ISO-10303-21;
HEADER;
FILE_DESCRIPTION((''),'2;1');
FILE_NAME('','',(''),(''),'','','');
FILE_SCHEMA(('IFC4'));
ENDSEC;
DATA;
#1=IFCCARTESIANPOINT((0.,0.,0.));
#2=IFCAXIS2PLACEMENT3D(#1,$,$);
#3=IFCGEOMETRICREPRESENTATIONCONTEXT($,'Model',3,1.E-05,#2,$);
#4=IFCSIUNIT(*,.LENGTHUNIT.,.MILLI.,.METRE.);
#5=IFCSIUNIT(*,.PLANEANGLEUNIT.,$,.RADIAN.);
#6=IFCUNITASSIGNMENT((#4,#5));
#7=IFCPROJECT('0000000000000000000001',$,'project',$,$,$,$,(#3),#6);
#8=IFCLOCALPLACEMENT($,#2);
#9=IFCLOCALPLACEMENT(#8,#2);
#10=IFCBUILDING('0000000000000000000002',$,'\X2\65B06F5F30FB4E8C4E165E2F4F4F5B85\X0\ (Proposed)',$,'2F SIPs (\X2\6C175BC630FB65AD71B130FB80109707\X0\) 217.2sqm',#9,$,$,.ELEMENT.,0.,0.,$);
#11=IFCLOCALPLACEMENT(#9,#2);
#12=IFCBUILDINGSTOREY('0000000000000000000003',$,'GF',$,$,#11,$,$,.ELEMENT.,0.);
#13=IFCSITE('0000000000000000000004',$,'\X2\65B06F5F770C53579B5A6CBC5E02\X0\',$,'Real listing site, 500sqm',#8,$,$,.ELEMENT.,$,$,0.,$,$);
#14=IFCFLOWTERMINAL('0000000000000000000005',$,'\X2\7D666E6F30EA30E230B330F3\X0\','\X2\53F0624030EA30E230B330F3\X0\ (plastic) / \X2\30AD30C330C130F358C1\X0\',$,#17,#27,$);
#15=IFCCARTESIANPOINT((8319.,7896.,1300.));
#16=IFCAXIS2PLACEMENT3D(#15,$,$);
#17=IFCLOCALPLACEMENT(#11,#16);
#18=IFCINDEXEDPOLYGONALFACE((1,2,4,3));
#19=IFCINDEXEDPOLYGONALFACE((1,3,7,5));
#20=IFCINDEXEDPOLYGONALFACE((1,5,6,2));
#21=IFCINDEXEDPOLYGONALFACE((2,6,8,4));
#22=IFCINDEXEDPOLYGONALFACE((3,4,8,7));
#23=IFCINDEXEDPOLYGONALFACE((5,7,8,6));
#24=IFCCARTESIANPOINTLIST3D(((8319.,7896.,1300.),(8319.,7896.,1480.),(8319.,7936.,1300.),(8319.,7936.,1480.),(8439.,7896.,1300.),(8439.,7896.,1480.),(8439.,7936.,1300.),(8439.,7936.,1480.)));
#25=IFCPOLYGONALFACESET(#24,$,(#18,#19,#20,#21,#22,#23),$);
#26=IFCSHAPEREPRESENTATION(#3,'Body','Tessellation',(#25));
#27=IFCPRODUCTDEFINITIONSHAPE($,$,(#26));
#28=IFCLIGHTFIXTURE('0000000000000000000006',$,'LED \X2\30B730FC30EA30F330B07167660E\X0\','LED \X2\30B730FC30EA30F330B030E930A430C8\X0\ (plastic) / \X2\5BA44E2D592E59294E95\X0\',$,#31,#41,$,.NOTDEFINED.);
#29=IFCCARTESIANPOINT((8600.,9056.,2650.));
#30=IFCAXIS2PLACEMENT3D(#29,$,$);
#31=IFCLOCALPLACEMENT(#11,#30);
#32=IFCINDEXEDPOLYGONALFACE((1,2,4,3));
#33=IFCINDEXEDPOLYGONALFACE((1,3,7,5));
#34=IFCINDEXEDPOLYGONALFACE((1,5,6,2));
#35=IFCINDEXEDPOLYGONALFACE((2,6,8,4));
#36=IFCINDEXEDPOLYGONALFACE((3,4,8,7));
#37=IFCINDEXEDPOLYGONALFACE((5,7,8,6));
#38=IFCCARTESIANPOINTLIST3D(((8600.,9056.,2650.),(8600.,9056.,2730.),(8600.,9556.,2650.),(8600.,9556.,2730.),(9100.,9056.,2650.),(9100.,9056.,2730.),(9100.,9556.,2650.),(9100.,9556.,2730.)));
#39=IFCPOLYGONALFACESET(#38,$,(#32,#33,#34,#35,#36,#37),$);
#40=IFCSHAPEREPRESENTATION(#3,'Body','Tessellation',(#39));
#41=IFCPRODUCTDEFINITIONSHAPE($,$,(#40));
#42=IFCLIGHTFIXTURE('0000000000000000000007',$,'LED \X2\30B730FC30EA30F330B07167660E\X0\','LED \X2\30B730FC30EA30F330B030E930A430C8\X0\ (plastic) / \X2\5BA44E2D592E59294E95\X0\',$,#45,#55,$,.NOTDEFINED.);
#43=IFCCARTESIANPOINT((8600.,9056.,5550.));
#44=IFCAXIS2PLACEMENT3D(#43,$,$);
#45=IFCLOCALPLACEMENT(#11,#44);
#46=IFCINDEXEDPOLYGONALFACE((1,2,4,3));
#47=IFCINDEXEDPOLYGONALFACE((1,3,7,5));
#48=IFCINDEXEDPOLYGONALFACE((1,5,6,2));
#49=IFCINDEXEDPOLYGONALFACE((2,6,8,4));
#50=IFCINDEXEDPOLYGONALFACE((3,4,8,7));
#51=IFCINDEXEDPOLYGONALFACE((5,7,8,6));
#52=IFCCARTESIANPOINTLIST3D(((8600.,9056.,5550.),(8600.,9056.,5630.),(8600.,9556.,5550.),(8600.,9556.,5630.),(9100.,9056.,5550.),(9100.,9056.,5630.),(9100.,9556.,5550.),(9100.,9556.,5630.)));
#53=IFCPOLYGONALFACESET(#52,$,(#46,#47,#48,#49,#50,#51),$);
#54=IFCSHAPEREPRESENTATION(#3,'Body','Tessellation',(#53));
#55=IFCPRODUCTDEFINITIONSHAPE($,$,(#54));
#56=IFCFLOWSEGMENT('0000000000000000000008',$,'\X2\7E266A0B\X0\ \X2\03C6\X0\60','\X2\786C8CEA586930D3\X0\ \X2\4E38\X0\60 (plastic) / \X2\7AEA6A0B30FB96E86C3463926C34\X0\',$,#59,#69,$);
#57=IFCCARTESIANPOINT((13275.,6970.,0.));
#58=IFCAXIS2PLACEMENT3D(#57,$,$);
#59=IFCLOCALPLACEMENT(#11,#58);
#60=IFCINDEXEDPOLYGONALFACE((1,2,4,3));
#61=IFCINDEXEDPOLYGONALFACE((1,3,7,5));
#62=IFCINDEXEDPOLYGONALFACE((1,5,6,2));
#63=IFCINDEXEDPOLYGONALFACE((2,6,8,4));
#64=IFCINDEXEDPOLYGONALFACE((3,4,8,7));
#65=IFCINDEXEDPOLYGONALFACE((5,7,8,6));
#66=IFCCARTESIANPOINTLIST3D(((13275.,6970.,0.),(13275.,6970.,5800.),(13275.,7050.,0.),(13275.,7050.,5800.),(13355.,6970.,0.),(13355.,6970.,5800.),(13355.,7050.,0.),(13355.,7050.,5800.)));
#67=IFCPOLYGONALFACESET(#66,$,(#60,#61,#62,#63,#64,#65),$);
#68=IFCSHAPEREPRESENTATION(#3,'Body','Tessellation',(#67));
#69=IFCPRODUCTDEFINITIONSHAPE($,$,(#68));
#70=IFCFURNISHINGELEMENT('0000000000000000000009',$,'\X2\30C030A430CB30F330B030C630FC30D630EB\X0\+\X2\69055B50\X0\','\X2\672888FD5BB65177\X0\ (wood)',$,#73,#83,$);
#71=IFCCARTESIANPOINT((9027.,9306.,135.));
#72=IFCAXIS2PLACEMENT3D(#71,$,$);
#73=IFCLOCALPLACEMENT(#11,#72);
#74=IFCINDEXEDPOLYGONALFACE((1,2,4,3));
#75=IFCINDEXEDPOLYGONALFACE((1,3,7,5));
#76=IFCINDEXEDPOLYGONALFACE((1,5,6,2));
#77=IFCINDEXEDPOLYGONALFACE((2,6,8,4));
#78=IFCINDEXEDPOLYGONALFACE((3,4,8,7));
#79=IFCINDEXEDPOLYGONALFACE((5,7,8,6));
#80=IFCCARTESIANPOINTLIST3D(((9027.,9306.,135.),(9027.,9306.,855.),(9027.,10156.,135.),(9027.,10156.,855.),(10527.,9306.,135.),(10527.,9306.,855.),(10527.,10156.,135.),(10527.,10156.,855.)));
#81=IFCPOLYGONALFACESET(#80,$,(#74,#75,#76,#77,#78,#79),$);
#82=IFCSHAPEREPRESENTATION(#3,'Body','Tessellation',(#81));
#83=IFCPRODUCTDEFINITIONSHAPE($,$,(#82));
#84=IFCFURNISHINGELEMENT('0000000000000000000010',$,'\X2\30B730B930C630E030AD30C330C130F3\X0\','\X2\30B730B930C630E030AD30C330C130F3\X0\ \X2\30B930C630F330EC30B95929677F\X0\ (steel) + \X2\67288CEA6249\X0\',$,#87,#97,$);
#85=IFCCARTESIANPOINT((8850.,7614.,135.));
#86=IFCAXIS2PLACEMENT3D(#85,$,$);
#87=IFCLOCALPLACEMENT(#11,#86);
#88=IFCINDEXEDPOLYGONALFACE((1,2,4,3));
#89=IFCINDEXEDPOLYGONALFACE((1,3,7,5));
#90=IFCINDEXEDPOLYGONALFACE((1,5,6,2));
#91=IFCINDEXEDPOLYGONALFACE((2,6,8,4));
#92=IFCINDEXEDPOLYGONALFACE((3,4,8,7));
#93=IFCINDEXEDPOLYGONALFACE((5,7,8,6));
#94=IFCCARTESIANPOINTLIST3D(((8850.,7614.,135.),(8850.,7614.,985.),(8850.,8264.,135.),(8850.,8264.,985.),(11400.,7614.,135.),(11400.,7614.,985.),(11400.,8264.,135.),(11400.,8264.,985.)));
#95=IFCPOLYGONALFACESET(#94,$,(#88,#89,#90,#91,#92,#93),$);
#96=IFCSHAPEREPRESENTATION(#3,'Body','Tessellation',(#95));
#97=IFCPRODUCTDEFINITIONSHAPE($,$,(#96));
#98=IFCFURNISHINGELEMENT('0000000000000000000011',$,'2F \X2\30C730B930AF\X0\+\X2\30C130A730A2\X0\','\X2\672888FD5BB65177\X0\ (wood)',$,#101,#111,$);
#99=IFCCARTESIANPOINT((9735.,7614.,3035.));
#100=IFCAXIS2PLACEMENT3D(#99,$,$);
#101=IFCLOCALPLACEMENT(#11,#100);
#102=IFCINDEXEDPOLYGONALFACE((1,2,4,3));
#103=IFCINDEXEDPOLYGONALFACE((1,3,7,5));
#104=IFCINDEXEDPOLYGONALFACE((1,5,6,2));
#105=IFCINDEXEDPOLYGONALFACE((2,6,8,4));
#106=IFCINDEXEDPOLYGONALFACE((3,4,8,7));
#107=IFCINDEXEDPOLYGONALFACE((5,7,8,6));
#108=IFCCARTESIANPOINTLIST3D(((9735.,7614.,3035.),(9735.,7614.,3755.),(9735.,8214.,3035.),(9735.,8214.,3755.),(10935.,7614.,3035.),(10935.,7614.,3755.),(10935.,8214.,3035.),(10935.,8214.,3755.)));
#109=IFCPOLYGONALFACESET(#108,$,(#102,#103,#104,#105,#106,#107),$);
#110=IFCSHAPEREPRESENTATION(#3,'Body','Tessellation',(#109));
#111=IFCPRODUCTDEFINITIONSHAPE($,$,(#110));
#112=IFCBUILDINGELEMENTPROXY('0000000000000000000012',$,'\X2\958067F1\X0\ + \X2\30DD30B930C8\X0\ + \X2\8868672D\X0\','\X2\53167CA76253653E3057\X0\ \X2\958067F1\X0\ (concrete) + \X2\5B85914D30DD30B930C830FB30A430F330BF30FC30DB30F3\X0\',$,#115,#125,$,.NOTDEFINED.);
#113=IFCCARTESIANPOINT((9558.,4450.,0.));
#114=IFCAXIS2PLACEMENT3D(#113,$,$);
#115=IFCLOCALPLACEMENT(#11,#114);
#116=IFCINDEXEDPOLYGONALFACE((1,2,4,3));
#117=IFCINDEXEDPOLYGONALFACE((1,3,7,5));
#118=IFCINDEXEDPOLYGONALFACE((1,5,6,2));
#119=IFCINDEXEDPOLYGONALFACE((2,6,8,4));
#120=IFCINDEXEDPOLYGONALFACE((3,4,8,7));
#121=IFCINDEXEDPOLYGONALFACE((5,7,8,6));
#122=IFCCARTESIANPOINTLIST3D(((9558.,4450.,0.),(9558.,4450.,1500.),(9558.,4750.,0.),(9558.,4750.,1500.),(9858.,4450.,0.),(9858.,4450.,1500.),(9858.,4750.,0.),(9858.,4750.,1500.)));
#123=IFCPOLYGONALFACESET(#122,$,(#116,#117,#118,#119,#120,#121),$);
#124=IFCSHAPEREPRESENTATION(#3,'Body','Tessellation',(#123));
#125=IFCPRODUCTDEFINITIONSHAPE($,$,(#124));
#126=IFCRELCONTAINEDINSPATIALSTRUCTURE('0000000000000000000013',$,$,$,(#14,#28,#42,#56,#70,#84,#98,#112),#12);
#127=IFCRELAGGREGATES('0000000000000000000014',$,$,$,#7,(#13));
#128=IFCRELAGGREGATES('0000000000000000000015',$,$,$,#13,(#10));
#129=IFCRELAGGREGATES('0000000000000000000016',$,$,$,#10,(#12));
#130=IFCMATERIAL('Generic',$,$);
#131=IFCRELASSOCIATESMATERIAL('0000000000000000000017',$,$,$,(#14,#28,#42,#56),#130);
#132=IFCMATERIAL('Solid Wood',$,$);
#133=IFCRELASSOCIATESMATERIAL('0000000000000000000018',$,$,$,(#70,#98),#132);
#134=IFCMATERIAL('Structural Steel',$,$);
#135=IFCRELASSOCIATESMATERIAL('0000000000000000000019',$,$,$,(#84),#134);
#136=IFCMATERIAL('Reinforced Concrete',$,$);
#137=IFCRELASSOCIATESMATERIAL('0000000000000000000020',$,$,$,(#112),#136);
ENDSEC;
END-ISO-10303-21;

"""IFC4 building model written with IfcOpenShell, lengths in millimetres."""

from ifc_helpers import new_model, si_unit, frame, frame_2d, origin, place, context, project, spatial, rectangle, extrude, material, element, save


model = new_model("IFC4")

# Units and contexts
model_context = context("Model", 3, precision=1e-05, world=origin())
ifc_project = project(units=[si_unit("LENGTHUNIT", "METRE", prefix="MILLI"), si_unit("PLANEANGLEUNIT", "RADIAN")], contexts=[model_context])

# Site, building, storey
site_placement = place(None, origin())
site = spatial("IfcSite", under=ifc_project, at=site_placement, Name="新潟県南魚沼市", ObjectType="Real listing site, 500sqm", CompositionType="ELEMENT", RefElevation=0.0)
building_placement = place(site_placement, origin())
building = spatial("IfcBuilding", under=site, at=building_placement, Name="新潟・二世帯住宅 (Proposed)", ObjectType="2F SIPs (気密・断熱・耐震) 217.2sqm", CompositionType="ELEMENT", ElevationOfRefHeight=0.0, ElevationOfTerrain=0.0)
storey_placement = place(building_placement, origin())
storey = spatial("IfcBuildingStorey", under=building, at=storey_placement, Name="GF", CompositionType="ELEMENT", Elevation=0.0)

# Shared definitions
ifc_material_1 = material(Name="Solid Wood")

# Shared definitions
ifc_material_2 = material(Name="Reinforced Concrete")

# Shared definitions
ifc_material_3 = material(Name="Structural Steel")

# Flow terminal
ifc_material_4 = material(Name="Generic")
flow_terminal_1_placement = place(storey_placement, frame((8319.0, 7896.0, 1300.0)))
element("IfcFlowTerminal", 1, at=flow_terminal_1_placement, inside=storey, material=ifc_material_4, Name="給湯リモコン", Description="台所リモコン (plastic) / キッチン壁", context=model_context, shape_type="SweptSolid", body=[
    extrude(rectangle(XDim=120.0, YDim=40.0, at=frame_2d((60.0, 20.0))), frame((8319.0, 7896.0, 1300.0)), (0.0, 0.0, 1.0), 180.0),
])

# Light fixtures
light_fixture_1_placement = place(storey_placement, frame((8600.0, 9056.0, 2650.0)))
element("IfcLightFixture", 2, at=light_fixture_1_placement, inside=storey, material=ifc_material_4, Name="LED シーリング照明", Description="LED シーリングライト (plastic) / 室中央天井", PredefinedType="NOTDEFINED", context=model_context, shape_type="SweptSolid", body=[
    extrude(rectangle(XDim=500.0, YDim=500.0, at=frame_2d((250.0, 250.0))), frame((8600.0, 9056.0, 2650.0)), (0.0, 0.0, 1.0), 80.0),
])
light_fixture_2_placement = place(storey_placement, frame((8600.0, 9056.0, 5550.0)))
element("IfcLightFixture", 3, at=light_fixture_2_placement, inside=storey, material=ifc_material_4, Name="LED シーリング照明", Description="LED シーリングライト (plastic) / 室中央天井", PredefinedType="NOTDEFINED", context=model_context, shape_type="SweptSolid", body=[
    extrude(rectangle(XDim=500.0, YDim=500.0, at=frame_2d((250.0, 250.0))), frame((8600.0, 9056.0, 5550.0)), (0.0, 0.0, 1.0), 80.0),
])

# Flow segment
flow_segment_placement = place(storey_placement, frame((13275.0, 6970.0, 0.0)))
element("IfcFlowSegment", 4, at=flow_segment_placement, inside=storey, material=ifc_material_4, Name="縦樋 φ60", Description="硬質塩ビ 丸60 (plastic) / 竪樋・雨水排水", context=model_context, shape_type="SweptSolid", body=[
    extrude(rectangle(XDim=80.0, YDim=80.0, at=frame_2d((40.0, 40.0))), frame((13275.0, 6970.0, 0.0)), (0.0, 0.0, 1.0), 5800.0),
])

# Furnishing elements
furnishing_1_placement = place(storey_placement, frame((9027.0, 9306.0, 135.0)))
element("IfcFurnishingElement", 5, at=furnishing_1_placement, inside=storey, material=ifc_material_1, Name="ダイニングテーブル+椅子", Description="木製家具 (wood)", context=model_context, shape_type="SweptSolid", body=[
    extrude(rectangle(XDim=1500.0, YDim=850.0, at=frame_2d((750.0, 425.0))), frame((9027.0, 9306.0, 135.0)), (0.0, 0.0, 1.0), 720.0),
])
furnishing_2_placement = place(storey_placement, frame((8850.0, 7614.0, 135.0)))
element("IfcFurnishingElement", 6, at=furnishing_2_placement, inside=storey, material=ifc_material_3, Name="システムキッチン", Description="システムキッチン ステンレス天板 (steel) + 木質扉", context=model_context, shape_type="SweptSolid", body=[
    extrude(rectangle(XDim=2550.0, YDim=650.0, at=frame_2d((1275.0, 325.0))), frame((8850.0, 7614.0, 135.0)), (0.0, 0.0, 1.0), 850.0),
])
furnishing_3_placement = place(storey_placement, frame((9735.0, 7614.0, 3035.0)))
element("IfcFurnishingElement", 7, at=furnishing_3_placement, inside=storey, material=ifc_material_1, Name="2F デスク+チェア", Description="木製家具 (wood)", context=model_context, shape_type="SweptSolid", body=[
    extrude(rectangle(XDim=1200.0, YDim=600.0, at=frame_2d((600.0, 300.0))), frame((9735.0, 7614.0, 3035.0)), (0.0, 0.0, 1.0), 720.0),
])

# Building element proxy
proxy_placement = place(storey_placement, frame((9558.0, 4450.0, 0.0)))
element("IfcBuildingElementProxy", 8, at=proxy_placement, inside=storey, material=ifc_material_2, Name="門柱 + ポスト + 表札", Description="化粧打放し 門柱 (concrete) + 宅配ポスト・インターホン", PredefinedType="NOTDEFINED", context=model_context, shape_type="SweptSolid", body=[
    extrude(rectangle(XDim=300.0, YDim=300.0, at=frame_2d((150.0, 150.0))), frame((9558.0, 4450.0, 0.0)), (0.0, 0.0, 1.0), 1500.0),
])

save(model, "model.ifc")
